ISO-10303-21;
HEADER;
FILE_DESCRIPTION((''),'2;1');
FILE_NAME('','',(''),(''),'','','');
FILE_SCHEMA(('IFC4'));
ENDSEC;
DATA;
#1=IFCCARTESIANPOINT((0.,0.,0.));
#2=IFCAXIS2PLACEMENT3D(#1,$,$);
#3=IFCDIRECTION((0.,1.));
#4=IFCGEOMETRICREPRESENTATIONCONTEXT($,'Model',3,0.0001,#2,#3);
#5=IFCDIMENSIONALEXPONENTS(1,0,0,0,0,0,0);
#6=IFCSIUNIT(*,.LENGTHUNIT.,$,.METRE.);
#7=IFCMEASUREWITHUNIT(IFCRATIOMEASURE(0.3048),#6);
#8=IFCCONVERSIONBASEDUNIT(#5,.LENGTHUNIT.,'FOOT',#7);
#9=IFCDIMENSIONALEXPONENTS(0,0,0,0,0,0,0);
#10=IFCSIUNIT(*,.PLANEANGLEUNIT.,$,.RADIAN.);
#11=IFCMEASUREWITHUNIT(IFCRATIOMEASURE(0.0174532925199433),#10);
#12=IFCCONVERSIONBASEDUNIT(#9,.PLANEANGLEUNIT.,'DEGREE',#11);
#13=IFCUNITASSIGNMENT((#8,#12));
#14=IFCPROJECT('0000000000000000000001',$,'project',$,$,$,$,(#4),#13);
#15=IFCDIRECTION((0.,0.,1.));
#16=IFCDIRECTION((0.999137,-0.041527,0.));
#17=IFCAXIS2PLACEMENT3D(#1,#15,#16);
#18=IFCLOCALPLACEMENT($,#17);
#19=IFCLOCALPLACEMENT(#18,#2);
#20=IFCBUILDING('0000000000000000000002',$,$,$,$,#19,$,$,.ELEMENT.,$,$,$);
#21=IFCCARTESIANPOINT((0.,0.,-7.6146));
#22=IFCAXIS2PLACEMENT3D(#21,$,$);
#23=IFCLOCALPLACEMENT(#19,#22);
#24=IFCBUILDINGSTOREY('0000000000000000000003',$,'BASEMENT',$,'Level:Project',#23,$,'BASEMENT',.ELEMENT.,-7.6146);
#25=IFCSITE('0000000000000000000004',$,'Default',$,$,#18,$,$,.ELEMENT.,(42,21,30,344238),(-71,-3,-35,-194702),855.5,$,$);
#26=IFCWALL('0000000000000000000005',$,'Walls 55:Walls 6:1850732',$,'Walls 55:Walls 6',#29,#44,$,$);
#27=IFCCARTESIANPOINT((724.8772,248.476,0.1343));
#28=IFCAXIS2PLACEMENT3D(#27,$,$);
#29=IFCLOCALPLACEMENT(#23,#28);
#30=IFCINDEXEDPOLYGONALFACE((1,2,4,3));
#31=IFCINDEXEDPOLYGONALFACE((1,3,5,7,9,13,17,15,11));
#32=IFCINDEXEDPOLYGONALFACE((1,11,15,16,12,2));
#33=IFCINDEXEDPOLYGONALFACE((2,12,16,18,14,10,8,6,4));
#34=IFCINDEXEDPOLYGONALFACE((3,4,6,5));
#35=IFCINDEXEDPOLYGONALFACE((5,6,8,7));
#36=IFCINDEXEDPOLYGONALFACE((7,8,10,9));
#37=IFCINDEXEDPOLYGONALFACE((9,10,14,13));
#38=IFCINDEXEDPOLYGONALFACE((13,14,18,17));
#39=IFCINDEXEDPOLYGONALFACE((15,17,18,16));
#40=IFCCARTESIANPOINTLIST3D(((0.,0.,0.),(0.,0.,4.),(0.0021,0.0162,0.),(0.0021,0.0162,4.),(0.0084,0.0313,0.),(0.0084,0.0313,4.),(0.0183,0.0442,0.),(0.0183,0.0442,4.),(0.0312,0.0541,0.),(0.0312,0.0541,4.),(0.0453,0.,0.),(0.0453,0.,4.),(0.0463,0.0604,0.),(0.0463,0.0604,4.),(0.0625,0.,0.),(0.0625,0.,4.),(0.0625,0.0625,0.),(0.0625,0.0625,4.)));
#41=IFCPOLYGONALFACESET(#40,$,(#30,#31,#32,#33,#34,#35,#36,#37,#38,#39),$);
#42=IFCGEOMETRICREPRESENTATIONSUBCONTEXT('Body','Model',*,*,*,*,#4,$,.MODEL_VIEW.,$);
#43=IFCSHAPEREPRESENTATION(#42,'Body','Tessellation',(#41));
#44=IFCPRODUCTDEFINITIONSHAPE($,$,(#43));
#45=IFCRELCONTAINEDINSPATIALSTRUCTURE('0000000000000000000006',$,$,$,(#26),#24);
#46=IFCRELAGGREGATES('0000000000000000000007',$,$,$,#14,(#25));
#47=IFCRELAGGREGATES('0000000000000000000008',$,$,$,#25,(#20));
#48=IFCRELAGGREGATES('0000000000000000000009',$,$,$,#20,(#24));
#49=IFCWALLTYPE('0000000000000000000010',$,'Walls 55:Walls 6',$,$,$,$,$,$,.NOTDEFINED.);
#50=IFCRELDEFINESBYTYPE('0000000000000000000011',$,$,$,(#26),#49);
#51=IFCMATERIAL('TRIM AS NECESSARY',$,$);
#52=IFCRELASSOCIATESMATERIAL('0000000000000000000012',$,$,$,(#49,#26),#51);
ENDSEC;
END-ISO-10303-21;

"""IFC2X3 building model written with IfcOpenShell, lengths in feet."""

from ifc_helpers import new_model, entity, si_unit, converted_unit, direction, frame, frame_2d, origin, place, context, subcontext, project, spatial, polyline, circle_curve, parameter, trimmed, segment, composite_curve, outline, extrude, material, type_object, element, save


model = new_model("IFC2X3")

# Units and contexts
model_context = context("Model", 3, precision=0.0001, world=origin(), true_north=direction((0.0, 1.0)))
body_context = subcontext(model_context, "Body", "Model", "MODEL_VIEW")
ifc_project = project(units=[converted_unit("LENGTHUNIT", "FOOT", entity("IfcRatioMeasure", 0.3048), si_unit("LENGTHUNIT", "METRE"), dimensions=[1, 0, 0, 0, 0, 0, 0]), converted_unit("PLANEANGLEUNIT", "DEGREE", entity("IfcRatioMeasure", 0.0174532925199433), si_unit("PLANEANGLEUNIT", "RADIAN"), dimensions=[0, 0, 0, 0, 0, 0, 0])], contexts=[model_context])

# Site, building, storey
site_placement = place(None, frame((0.0, 0.0, 0.0), z_axis=(0.0, 0.0, 1.0), x_axis=(0.999137, -0.041527, 0.0)))
site = spatial("IfcSite", under=ifc_project, at=site_placement, Name="Default", CompositionType="ELEMENT", RefLatitude=(42, 21, 30, 344238), RefLongitude=(-71, -3, -35, -194702), RefElevation=855.5)
building_placement = place(site_placement, origin())
building = spatial("IfcBuilding", under=site, at=building_placement, CompositionType="ELEMENT")
storey_placement = place(building_placement, frame((0.0, 0.0, -7.6146)))
storey = spatial("IfcBuildingStorey", under=building, at=storey_placement, Name="BASEMENT", ObjectType="Level:Project", LongName="BASEMENT", CompositionType="ELEMENT", Elevation=-7.6146)

# Wall
ifc_material_1 = material(Name="TRIM AS NECESSARY")
wall_type_1 = type_object("IfcWallType", Name="Walls 55:Walls 6", PredefinedType="NOTDEFINED", material=ifc_material_1)
wall_1_placement = place(storey_placement, frame((724.8772, 248.476, 0.1343)))
element("IfcWall", 1, at=wall_1_placement, inside=storey, type_object=wall_type_1, material=ifc_material_1, Name="Walls 55:Walls 6:1850732", ObjectType="Walls 55:Walls 6", context=body_context, shape_type="SweptSolid", body=[
    extrude(outline(composite_curve([segment(polyline([(-0.0156, -0.0199), (0.0469, -0.0199)]), True, "CONTINUOUS"), segment(trimmed(circle_curve(frame_2d((-0.0156, -0.0199), x_axis=(1.0, 0.0)), 0.0625), [parameter(360.0)], [parameter(90.0)], True, "PARAMETER"), True, "CONTINUOUS"), segment(polyline([(-0.0156, 0.0426), (-0.0156, -0.0027)]), True, "CONTINUOUS"), segment(polyline([(-0.0156, -0.0027), (-0.0156, -0.0199)]), True, "CONTINUOUS")], self_intersect=False)), frame((0.0426, 0.0156, 0.0), z_axis=(0.0, 0.0, 1.0), x_axis=(0.0, 1.0, 0.0)), (0.0, 0.0, 1.0), 4.0),
])

save(model, "model.ifc")
